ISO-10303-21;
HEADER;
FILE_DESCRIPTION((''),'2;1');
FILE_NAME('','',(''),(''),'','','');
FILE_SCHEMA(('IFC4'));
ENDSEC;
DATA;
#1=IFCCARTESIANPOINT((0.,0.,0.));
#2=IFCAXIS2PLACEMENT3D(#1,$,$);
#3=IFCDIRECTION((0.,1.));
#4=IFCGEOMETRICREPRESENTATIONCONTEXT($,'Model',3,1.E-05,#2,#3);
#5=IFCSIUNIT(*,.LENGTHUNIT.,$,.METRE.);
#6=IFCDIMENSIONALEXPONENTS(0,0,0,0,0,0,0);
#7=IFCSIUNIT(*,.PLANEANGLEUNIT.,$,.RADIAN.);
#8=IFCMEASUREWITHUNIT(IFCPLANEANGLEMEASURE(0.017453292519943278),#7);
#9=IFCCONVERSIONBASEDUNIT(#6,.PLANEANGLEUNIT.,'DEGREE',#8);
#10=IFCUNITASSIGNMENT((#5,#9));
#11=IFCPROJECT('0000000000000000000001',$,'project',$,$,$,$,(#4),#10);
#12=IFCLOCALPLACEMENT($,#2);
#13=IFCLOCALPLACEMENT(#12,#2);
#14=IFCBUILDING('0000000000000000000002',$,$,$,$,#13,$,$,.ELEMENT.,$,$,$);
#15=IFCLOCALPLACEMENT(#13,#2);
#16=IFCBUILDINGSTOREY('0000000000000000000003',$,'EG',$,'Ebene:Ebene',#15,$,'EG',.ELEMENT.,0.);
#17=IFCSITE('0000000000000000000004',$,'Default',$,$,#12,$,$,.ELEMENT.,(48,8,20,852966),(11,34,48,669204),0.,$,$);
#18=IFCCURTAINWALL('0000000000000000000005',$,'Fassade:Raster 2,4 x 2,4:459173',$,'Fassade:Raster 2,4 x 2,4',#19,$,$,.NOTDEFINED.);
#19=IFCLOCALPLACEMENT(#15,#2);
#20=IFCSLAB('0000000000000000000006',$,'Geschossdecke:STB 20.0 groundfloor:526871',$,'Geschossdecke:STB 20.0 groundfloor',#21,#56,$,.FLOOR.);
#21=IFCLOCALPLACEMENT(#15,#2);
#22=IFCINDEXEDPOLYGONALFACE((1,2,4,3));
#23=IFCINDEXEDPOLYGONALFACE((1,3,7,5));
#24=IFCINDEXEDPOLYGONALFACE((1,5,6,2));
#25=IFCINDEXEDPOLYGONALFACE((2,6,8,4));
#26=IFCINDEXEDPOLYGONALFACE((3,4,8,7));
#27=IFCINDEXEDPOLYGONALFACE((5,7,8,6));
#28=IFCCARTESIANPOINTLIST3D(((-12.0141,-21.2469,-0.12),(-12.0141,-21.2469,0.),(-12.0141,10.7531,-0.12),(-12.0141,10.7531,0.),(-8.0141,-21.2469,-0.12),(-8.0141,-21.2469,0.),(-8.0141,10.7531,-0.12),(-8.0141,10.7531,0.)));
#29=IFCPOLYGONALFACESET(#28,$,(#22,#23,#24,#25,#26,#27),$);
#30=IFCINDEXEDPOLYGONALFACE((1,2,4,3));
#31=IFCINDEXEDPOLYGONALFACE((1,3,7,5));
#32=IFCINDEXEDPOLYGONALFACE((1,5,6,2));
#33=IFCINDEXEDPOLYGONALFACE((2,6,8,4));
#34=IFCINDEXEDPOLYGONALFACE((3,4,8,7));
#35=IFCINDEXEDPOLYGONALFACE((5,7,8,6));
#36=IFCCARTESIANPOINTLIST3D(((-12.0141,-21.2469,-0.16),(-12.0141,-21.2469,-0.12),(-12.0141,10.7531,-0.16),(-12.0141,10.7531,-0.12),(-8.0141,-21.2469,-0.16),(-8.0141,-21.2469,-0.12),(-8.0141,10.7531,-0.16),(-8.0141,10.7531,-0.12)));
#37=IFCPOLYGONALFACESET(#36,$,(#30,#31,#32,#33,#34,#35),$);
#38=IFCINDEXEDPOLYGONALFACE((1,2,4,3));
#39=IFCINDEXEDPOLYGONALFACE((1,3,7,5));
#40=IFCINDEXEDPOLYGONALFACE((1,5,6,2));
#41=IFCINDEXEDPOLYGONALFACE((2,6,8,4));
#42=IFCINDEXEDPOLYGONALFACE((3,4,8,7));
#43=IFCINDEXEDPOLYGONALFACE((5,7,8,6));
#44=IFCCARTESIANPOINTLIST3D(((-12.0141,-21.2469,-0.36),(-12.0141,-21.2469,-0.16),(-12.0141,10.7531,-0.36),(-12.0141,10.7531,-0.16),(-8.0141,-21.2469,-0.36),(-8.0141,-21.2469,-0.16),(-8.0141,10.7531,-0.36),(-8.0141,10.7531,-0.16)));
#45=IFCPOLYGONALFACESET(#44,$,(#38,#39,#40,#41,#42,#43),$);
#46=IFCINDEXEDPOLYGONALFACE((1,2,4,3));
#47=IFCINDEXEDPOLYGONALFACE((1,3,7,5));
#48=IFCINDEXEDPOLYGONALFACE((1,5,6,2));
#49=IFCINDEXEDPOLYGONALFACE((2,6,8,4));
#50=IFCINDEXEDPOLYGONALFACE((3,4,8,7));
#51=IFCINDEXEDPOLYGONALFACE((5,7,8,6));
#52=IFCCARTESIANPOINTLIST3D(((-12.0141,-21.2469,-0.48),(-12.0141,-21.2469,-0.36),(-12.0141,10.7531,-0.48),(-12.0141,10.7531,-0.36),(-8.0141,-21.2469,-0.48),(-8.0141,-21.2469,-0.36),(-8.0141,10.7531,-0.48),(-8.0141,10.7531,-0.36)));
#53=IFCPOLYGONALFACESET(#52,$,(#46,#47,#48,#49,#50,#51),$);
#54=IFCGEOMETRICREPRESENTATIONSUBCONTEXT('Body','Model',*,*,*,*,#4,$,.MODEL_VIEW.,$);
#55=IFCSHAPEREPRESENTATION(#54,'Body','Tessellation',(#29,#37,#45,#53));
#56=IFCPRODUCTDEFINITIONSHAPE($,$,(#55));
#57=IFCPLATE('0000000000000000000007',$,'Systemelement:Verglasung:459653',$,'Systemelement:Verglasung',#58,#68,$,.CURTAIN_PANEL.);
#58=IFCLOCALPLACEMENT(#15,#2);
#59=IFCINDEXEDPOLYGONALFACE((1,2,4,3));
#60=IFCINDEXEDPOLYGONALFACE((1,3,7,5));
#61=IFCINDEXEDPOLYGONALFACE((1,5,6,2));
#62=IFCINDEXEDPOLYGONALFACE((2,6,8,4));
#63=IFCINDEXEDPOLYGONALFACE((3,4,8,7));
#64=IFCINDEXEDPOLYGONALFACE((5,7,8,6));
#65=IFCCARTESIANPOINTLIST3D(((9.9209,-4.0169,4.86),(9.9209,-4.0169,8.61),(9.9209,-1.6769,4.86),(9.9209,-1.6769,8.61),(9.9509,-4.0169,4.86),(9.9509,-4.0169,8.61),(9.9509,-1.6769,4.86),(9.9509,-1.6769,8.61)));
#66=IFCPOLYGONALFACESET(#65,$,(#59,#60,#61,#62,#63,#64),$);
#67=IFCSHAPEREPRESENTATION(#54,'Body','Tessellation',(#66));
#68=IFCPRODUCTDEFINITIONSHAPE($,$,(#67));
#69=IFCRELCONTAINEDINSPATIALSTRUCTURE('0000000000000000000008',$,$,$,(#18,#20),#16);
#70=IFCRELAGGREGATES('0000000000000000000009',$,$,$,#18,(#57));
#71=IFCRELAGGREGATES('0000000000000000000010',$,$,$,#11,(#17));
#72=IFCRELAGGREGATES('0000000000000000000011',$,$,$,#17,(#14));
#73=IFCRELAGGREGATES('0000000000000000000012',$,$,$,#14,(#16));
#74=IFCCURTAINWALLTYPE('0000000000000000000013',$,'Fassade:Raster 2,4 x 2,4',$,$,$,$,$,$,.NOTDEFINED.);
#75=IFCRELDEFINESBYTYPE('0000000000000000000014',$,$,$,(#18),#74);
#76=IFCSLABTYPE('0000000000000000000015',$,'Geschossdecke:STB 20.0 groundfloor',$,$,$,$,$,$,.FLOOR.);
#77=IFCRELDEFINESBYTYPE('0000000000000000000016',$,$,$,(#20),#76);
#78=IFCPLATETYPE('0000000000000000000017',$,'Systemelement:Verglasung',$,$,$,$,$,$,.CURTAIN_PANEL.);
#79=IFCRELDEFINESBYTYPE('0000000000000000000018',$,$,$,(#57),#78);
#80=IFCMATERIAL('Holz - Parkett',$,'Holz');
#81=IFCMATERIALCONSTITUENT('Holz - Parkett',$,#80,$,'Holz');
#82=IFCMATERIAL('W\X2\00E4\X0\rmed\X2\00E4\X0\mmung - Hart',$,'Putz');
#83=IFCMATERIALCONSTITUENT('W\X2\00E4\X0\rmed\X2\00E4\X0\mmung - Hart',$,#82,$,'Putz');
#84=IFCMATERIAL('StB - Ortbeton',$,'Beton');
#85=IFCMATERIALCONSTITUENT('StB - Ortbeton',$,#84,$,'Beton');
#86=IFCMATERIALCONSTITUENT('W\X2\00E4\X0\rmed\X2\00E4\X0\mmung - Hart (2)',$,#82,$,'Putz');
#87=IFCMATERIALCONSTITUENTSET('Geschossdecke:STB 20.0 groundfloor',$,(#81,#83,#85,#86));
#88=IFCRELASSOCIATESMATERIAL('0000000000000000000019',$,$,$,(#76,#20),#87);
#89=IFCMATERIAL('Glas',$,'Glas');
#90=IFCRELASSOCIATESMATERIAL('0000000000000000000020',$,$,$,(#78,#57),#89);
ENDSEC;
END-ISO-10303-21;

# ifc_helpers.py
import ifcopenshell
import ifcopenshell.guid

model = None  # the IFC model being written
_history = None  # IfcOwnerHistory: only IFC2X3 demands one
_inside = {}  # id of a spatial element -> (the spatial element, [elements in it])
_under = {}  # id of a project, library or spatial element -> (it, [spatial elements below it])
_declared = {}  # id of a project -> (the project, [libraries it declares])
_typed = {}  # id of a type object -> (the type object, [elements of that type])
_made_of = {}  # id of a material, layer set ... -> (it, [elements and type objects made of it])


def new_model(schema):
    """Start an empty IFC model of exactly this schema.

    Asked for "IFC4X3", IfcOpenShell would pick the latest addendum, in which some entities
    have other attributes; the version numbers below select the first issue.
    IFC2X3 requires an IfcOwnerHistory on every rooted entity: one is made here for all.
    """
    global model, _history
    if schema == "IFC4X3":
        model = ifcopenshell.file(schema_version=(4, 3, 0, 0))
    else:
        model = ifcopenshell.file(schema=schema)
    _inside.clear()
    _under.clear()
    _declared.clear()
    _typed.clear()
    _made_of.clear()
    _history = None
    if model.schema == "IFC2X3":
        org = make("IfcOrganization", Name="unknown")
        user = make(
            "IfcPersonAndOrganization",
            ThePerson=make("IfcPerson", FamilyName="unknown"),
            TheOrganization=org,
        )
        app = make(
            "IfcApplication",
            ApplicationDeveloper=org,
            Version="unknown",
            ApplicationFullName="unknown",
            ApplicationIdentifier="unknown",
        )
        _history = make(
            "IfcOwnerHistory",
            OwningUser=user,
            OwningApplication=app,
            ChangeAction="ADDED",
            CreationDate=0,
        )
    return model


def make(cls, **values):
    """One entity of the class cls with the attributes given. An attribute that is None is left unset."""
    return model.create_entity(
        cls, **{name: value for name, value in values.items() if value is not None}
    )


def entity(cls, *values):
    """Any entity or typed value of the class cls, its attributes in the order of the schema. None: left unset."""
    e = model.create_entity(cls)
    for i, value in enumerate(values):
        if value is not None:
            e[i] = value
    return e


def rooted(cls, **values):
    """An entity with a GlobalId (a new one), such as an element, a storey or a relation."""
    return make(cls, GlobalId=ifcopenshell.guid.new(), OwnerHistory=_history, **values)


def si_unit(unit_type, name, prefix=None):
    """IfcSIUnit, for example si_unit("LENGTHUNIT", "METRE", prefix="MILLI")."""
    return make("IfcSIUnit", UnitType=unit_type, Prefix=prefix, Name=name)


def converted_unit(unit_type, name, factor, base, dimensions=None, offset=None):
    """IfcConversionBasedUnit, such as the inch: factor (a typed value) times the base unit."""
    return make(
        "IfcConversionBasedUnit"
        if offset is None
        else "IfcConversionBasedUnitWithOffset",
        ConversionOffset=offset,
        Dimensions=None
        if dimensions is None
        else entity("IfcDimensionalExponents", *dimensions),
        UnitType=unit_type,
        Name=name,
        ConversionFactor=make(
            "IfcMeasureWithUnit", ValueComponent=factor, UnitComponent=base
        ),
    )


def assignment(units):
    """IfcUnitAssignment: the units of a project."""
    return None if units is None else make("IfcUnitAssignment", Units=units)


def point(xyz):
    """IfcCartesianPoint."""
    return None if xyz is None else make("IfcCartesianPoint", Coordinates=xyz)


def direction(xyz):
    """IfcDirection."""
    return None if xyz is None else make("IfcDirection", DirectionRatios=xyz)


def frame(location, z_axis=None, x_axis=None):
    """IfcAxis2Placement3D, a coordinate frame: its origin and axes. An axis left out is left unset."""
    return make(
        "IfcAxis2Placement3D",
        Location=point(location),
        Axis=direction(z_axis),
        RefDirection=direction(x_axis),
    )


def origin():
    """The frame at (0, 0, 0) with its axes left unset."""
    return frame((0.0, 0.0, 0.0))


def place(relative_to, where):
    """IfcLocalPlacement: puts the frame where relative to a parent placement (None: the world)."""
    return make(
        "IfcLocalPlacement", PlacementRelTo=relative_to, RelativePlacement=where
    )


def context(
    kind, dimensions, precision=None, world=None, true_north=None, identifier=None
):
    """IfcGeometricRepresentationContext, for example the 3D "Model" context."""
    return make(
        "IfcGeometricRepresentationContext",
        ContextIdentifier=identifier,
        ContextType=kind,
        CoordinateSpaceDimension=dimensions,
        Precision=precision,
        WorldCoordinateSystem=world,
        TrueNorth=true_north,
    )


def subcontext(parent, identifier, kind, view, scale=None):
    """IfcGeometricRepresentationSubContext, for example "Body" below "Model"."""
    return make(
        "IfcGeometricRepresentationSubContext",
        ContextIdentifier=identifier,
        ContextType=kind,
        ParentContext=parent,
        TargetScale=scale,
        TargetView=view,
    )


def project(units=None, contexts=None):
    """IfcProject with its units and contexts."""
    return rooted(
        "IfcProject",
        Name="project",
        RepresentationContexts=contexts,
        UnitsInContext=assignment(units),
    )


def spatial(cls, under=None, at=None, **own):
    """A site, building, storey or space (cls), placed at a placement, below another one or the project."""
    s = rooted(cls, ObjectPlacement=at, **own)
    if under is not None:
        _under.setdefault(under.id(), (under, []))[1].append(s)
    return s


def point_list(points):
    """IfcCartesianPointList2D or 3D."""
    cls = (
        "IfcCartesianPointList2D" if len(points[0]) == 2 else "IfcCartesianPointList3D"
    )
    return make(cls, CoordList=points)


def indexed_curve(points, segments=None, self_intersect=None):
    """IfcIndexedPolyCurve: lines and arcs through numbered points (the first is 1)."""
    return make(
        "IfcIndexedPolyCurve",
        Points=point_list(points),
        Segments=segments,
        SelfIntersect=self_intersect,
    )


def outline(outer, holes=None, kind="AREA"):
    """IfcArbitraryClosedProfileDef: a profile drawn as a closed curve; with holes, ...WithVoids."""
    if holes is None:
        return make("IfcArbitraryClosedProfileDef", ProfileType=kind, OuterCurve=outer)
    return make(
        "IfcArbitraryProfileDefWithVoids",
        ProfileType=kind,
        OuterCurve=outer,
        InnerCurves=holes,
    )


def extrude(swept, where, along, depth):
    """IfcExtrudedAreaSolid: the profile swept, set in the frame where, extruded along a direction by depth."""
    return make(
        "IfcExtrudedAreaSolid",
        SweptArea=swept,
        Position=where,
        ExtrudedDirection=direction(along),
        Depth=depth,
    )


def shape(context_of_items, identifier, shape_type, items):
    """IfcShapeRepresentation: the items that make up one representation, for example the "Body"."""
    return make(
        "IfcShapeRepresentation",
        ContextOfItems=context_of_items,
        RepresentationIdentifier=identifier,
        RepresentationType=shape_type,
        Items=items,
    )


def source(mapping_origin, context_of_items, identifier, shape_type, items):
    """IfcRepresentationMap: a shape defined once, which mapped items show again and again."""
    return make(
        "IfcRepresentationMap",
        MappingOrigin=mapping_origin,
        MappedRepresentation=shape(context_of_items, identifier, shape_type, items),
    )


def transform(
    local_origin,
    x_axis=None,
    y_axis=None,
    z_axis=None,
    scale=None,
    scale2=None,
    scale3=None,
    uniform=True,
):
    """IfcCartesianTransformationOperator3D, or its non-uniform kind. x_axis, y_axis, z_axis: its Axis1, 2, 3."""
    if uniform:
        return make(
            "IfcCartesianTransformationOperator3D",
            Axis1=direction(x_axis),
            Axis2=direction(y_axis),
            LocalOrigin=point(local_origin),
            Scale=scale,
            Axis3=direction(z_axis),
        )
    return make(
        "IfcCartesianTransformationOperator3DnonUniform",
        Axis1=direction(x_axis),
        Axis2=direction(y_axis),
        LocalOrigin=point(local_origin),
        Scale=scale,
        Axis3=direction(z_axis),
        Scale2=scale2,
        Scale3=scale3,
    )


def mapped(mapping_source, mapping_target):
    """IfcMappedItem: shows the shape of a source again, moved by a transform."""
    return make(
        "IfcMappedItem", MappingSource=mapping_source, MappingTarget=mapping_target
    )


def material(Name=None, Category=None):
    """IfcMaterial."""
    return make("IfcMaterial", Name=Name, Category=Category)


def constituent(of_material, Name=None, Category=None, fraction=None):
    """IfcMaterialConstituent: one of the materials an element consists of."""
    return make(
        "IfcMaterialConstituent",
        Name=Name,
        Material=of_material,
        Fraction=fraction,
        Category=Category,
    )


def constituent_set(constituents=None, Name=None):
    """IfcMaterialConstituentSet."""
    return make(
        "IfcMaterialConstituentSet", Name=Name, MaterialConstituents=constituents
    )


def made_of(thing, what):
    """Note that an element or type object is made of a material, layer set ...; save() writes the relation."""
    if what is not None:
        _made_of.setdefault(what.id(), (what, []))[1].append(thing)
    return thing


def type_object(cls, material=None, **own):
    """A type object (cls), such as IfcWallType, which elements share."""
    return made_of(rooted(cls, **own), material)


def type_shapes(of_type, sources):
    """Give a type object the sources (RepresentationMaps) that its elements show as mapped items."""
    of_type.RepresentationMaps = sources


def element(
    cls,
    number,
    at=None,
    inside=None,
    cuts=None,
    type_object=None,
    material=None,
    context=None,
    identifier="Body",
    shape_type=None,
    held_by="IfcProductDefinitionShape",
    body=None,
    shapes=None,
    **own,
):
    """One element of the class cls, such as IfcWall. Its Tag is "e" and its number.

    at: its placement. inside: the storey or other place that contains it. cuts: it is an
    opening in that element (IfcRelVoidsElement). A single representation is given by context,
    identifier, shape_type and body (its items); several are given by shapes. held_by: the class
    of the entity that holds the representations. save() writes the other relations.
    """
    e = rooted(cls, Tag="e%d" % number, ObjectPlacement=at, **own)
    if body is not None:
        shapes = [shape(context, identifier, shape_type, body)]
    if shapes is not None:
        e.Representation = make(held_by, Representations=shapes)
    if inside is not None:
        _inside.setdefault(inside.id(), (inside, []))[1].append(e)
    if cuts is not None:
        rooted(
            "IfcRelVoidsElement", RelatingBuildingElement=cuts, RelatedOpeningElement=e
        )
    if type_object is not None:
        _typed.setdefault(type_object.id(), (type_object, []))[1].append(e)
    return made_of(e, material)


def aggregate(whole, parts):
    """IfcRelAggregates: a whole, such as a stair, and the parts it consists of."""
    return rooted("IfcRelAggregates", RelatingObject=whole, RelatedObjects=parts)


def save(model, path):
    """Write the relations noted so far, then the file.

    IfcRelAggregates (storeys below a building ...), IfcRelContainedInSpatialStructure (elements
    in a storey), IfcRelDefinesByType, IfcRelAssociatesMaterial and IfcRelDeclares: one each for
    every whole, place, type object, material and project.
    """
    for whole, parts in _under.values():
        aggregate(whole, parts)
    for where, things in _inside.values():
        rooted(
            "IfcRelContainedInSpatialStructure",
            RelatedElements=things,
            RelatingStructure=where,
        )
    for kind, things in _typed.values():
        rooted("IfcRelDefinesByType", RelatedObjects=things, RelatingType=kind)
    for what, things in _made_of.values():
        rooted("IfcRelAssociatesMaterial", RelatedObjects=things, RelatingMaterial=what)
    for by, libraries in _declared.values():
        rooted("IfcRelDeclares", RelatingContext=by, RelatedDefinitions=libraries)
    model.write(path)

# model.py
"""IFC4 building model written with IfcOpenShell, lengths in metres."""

from ifc_helpers import new_model, entity, si_unit, converted_unit, direction, frame, origin, place, context, subcontext, project, spatial, indexed_curve, outline, extrude, source, transform, mapped, material, constituent, constituent_set, type_object, type_shapes, element, aggregate, save


model = new_model("IFC4")

# Units and contexts
model_context = context("Model", 3, precision=1e-05, world=origin(), true_north=direction((0.0, 1.0)))
body_context = subcontext(model_context, "Body", "Model", "MODEL_VIEW")
ifc_project = project(units=[si_unit("LENGTHUNIT", "METRE"), converted_unit("PLANEANGLEUNIT", "DEGREE", entity("IfcPlaneAngleMeasure", 0.017453292519943278), si_unit("PLANEANGLEUNIT", "RADIAN"), dimensions=[0, 0, 0, 0, 0, 0, 0])], contexts=[model_context])

# Site, building, storey
site_placement = place(None, origin())
site = spatial("IfcSite", under=ifc_project, at=site_placement, Name="Default", CompositionType="ELEMENT", RefLatitude=(48, 8, 20, 852966), RefLongitude=(11, 34, 48, 669204), RefElevation=0.0)
building_placement = place(site_placement, origin())
building = spatial("IfcBuilding", under=site, at=building_placement, CompositionType="ELEMENT")
storey_placement = place(building_placement, origin())
storey = spatial("IfcBuildingStorey", under=building, at=storey_placement, Name="EG", ObjectType="Ebene:Ebene", LongName="EG", CompositionType="ELEMENT", Elevation=0.0)

# Curtain wall
curtain_wall_type = type_object("IfcCurtainWallType", Name="Fassade:Raster 2,4 x 2,4", PredefinedType="NOTDEFINED")
curtain_wall_1_placement = place(storey_placement, origin())
curtain_wall_1 = element("IfcCurtainWall", 1, at=curtain_wall_1_placement, inside=storey, type_object=curtain_wall_type, Name="Fassade:Raster 2,4 x 2,4:459173", ObjectType="Fassade:Raster 2,4 x 2,4", PredefinedType="NOTDEFINED")

# Slab
ifc_material_1 = material(Name="Holz - Parkett", Category="Holz")
ifc_constituent_1 = constituent(ifc_material_1, Name="Holz - Parkett", Category="Holz")
ifc_material_2 = material(Name="Wärmedämmung - Hart", Category="Putz")
ifc_constituent_2 = constituent(ifc_material_2, Name="Wärmedämmung - Hart", Category="Putz")
ifc_material_3 = material(Name="StB - Ortbeton", Category="Beton")
ifc_constituent_3 = constituent(ifc_material_3, Name="StB - Ortbeton", Category="Beton")
ifc_constituent_4 = constituent(ifc_material_2, Name="Wärmedämmung - Hart (2)", Category="Putz")
ifc_constituent_set = constituent_set(constituents=[ifc_constituent_1, ifc_constituent_2, ifc_constituent_3, ifc_constituent_4], Name="Geschossdecke:STB 20.0 groundfloor")
slab_type = type_object("IfcSlabType", Name="Geschossdecke:STB 20.0 groundfloor", PredefinedType="FLOOR", material=ifc_constituent_set)
slab_1_placement = place(storey_placement, origin())
element("IfcSlab", 2, at=slab_1_placement, inside=storey, type_object=slab_type, material=ifc_constituent_set, Name="Geschossdecke:STB 20.0 groundfloor:526871", ObjectType="Geschossdecke:STB 20.0 groundfloor", PredefinedType="FLOOR", context=body_context, shape_type="SweptSolid", body=[
    extrude(outline(indexed_curve([(-2.0, -16.0), (2.0, -16.0), (2.0, 16.0), (-2.0, 16.0), (-2.0, -16.0)], self_intersect=False)), frame((-10.0141, -5.2469, -0.12)), (0.0, 0.0, 1.0), 0.12),
    extrude(outline(indexed_curve([(-2.0, -16.0), (2.0, -16.0), (2.0, 16.0), (-2.0, 16.0), (-2.0, -16.0)], self_intersect=False)), frame((-10.0141, -5.2469, -0.16)), (0.0, 0.0, 1.0), 0.04),
    extrude(outline(indexed_curve([(-2.0, -16.0), (2.0, -16.0), (2.0, 16.0), (-2.0, 16.0), (-2.0, -16.0)], self_intersect=False)), frame((-10.0141, -5.2469, -0.36)), (0.0, 0.0, 1.0), 0.2),
    extrude(outline(indexed_curve([(-16.0, -2.0), (16.0, -2.0), (16.0, 2.0), (-16.0, 2.0), (-16.0, -2.0)], self_intersect=False)), frame((-10.0141, -5.2469, -0.48), z_axis=(0.0, 0.0, 1.0), x_axis=(0.0, -1.0, 0.0)), (0.0, 0.0, 1.0), 0.12),
])

# Plate
ifc_material_4 = material(Name="Glas", Category="Glas")
plate_type_1 = type_object("IfcPlateType", Name="Systemelement:Verglasung", PredefinedType="CURTAIN_PANEL", material=ifc_material_4)
shared_shape_1 = source(origin(), body_context, "Body", "SweptSolid", [
    extrude(outline(indexed_curve([(-0.015, -1.17), (0.015, -1.17), (0.015, 1.17), (-0.015, 1.17), (-0.015, -1.17)], self_intersect=False)), frame((0.0, 0.0, 0.0), z_axis=(0.0, 0.0, 1.0), x_axis=(0.0, 1.0, 0.0)), (0.0, 0.0, 1.0), 3.75),
])
type_shapes(plate_type_1, [shared_shape_1])
plate_1_placement = place(curtain_wall_1_placement, frame((9.9359, -2.8469, 4.86), z_axis=(0.0, 0.0, 1.0), x_axis=(0.0, 1.0, 0.0)))
plate_1 = element("IfcPlate", 3, at=plate_1_placement, type_object=plate_type_1, material=ifc_material_4, Name="Systemelement:Verglasung:459653", ObjectType="Systemelement:Verglasung", PredefinedType="CURTAIN_PANEL", context=body_context, shape_type="MappedRepresentation", body=[
    mapped(shared_shape_1, transform((0.0, 0.0, 0.0), scale=1.0)),
])
aggregate(curtain_wall_1, [plate_1])

save(model, "model.ifc")
